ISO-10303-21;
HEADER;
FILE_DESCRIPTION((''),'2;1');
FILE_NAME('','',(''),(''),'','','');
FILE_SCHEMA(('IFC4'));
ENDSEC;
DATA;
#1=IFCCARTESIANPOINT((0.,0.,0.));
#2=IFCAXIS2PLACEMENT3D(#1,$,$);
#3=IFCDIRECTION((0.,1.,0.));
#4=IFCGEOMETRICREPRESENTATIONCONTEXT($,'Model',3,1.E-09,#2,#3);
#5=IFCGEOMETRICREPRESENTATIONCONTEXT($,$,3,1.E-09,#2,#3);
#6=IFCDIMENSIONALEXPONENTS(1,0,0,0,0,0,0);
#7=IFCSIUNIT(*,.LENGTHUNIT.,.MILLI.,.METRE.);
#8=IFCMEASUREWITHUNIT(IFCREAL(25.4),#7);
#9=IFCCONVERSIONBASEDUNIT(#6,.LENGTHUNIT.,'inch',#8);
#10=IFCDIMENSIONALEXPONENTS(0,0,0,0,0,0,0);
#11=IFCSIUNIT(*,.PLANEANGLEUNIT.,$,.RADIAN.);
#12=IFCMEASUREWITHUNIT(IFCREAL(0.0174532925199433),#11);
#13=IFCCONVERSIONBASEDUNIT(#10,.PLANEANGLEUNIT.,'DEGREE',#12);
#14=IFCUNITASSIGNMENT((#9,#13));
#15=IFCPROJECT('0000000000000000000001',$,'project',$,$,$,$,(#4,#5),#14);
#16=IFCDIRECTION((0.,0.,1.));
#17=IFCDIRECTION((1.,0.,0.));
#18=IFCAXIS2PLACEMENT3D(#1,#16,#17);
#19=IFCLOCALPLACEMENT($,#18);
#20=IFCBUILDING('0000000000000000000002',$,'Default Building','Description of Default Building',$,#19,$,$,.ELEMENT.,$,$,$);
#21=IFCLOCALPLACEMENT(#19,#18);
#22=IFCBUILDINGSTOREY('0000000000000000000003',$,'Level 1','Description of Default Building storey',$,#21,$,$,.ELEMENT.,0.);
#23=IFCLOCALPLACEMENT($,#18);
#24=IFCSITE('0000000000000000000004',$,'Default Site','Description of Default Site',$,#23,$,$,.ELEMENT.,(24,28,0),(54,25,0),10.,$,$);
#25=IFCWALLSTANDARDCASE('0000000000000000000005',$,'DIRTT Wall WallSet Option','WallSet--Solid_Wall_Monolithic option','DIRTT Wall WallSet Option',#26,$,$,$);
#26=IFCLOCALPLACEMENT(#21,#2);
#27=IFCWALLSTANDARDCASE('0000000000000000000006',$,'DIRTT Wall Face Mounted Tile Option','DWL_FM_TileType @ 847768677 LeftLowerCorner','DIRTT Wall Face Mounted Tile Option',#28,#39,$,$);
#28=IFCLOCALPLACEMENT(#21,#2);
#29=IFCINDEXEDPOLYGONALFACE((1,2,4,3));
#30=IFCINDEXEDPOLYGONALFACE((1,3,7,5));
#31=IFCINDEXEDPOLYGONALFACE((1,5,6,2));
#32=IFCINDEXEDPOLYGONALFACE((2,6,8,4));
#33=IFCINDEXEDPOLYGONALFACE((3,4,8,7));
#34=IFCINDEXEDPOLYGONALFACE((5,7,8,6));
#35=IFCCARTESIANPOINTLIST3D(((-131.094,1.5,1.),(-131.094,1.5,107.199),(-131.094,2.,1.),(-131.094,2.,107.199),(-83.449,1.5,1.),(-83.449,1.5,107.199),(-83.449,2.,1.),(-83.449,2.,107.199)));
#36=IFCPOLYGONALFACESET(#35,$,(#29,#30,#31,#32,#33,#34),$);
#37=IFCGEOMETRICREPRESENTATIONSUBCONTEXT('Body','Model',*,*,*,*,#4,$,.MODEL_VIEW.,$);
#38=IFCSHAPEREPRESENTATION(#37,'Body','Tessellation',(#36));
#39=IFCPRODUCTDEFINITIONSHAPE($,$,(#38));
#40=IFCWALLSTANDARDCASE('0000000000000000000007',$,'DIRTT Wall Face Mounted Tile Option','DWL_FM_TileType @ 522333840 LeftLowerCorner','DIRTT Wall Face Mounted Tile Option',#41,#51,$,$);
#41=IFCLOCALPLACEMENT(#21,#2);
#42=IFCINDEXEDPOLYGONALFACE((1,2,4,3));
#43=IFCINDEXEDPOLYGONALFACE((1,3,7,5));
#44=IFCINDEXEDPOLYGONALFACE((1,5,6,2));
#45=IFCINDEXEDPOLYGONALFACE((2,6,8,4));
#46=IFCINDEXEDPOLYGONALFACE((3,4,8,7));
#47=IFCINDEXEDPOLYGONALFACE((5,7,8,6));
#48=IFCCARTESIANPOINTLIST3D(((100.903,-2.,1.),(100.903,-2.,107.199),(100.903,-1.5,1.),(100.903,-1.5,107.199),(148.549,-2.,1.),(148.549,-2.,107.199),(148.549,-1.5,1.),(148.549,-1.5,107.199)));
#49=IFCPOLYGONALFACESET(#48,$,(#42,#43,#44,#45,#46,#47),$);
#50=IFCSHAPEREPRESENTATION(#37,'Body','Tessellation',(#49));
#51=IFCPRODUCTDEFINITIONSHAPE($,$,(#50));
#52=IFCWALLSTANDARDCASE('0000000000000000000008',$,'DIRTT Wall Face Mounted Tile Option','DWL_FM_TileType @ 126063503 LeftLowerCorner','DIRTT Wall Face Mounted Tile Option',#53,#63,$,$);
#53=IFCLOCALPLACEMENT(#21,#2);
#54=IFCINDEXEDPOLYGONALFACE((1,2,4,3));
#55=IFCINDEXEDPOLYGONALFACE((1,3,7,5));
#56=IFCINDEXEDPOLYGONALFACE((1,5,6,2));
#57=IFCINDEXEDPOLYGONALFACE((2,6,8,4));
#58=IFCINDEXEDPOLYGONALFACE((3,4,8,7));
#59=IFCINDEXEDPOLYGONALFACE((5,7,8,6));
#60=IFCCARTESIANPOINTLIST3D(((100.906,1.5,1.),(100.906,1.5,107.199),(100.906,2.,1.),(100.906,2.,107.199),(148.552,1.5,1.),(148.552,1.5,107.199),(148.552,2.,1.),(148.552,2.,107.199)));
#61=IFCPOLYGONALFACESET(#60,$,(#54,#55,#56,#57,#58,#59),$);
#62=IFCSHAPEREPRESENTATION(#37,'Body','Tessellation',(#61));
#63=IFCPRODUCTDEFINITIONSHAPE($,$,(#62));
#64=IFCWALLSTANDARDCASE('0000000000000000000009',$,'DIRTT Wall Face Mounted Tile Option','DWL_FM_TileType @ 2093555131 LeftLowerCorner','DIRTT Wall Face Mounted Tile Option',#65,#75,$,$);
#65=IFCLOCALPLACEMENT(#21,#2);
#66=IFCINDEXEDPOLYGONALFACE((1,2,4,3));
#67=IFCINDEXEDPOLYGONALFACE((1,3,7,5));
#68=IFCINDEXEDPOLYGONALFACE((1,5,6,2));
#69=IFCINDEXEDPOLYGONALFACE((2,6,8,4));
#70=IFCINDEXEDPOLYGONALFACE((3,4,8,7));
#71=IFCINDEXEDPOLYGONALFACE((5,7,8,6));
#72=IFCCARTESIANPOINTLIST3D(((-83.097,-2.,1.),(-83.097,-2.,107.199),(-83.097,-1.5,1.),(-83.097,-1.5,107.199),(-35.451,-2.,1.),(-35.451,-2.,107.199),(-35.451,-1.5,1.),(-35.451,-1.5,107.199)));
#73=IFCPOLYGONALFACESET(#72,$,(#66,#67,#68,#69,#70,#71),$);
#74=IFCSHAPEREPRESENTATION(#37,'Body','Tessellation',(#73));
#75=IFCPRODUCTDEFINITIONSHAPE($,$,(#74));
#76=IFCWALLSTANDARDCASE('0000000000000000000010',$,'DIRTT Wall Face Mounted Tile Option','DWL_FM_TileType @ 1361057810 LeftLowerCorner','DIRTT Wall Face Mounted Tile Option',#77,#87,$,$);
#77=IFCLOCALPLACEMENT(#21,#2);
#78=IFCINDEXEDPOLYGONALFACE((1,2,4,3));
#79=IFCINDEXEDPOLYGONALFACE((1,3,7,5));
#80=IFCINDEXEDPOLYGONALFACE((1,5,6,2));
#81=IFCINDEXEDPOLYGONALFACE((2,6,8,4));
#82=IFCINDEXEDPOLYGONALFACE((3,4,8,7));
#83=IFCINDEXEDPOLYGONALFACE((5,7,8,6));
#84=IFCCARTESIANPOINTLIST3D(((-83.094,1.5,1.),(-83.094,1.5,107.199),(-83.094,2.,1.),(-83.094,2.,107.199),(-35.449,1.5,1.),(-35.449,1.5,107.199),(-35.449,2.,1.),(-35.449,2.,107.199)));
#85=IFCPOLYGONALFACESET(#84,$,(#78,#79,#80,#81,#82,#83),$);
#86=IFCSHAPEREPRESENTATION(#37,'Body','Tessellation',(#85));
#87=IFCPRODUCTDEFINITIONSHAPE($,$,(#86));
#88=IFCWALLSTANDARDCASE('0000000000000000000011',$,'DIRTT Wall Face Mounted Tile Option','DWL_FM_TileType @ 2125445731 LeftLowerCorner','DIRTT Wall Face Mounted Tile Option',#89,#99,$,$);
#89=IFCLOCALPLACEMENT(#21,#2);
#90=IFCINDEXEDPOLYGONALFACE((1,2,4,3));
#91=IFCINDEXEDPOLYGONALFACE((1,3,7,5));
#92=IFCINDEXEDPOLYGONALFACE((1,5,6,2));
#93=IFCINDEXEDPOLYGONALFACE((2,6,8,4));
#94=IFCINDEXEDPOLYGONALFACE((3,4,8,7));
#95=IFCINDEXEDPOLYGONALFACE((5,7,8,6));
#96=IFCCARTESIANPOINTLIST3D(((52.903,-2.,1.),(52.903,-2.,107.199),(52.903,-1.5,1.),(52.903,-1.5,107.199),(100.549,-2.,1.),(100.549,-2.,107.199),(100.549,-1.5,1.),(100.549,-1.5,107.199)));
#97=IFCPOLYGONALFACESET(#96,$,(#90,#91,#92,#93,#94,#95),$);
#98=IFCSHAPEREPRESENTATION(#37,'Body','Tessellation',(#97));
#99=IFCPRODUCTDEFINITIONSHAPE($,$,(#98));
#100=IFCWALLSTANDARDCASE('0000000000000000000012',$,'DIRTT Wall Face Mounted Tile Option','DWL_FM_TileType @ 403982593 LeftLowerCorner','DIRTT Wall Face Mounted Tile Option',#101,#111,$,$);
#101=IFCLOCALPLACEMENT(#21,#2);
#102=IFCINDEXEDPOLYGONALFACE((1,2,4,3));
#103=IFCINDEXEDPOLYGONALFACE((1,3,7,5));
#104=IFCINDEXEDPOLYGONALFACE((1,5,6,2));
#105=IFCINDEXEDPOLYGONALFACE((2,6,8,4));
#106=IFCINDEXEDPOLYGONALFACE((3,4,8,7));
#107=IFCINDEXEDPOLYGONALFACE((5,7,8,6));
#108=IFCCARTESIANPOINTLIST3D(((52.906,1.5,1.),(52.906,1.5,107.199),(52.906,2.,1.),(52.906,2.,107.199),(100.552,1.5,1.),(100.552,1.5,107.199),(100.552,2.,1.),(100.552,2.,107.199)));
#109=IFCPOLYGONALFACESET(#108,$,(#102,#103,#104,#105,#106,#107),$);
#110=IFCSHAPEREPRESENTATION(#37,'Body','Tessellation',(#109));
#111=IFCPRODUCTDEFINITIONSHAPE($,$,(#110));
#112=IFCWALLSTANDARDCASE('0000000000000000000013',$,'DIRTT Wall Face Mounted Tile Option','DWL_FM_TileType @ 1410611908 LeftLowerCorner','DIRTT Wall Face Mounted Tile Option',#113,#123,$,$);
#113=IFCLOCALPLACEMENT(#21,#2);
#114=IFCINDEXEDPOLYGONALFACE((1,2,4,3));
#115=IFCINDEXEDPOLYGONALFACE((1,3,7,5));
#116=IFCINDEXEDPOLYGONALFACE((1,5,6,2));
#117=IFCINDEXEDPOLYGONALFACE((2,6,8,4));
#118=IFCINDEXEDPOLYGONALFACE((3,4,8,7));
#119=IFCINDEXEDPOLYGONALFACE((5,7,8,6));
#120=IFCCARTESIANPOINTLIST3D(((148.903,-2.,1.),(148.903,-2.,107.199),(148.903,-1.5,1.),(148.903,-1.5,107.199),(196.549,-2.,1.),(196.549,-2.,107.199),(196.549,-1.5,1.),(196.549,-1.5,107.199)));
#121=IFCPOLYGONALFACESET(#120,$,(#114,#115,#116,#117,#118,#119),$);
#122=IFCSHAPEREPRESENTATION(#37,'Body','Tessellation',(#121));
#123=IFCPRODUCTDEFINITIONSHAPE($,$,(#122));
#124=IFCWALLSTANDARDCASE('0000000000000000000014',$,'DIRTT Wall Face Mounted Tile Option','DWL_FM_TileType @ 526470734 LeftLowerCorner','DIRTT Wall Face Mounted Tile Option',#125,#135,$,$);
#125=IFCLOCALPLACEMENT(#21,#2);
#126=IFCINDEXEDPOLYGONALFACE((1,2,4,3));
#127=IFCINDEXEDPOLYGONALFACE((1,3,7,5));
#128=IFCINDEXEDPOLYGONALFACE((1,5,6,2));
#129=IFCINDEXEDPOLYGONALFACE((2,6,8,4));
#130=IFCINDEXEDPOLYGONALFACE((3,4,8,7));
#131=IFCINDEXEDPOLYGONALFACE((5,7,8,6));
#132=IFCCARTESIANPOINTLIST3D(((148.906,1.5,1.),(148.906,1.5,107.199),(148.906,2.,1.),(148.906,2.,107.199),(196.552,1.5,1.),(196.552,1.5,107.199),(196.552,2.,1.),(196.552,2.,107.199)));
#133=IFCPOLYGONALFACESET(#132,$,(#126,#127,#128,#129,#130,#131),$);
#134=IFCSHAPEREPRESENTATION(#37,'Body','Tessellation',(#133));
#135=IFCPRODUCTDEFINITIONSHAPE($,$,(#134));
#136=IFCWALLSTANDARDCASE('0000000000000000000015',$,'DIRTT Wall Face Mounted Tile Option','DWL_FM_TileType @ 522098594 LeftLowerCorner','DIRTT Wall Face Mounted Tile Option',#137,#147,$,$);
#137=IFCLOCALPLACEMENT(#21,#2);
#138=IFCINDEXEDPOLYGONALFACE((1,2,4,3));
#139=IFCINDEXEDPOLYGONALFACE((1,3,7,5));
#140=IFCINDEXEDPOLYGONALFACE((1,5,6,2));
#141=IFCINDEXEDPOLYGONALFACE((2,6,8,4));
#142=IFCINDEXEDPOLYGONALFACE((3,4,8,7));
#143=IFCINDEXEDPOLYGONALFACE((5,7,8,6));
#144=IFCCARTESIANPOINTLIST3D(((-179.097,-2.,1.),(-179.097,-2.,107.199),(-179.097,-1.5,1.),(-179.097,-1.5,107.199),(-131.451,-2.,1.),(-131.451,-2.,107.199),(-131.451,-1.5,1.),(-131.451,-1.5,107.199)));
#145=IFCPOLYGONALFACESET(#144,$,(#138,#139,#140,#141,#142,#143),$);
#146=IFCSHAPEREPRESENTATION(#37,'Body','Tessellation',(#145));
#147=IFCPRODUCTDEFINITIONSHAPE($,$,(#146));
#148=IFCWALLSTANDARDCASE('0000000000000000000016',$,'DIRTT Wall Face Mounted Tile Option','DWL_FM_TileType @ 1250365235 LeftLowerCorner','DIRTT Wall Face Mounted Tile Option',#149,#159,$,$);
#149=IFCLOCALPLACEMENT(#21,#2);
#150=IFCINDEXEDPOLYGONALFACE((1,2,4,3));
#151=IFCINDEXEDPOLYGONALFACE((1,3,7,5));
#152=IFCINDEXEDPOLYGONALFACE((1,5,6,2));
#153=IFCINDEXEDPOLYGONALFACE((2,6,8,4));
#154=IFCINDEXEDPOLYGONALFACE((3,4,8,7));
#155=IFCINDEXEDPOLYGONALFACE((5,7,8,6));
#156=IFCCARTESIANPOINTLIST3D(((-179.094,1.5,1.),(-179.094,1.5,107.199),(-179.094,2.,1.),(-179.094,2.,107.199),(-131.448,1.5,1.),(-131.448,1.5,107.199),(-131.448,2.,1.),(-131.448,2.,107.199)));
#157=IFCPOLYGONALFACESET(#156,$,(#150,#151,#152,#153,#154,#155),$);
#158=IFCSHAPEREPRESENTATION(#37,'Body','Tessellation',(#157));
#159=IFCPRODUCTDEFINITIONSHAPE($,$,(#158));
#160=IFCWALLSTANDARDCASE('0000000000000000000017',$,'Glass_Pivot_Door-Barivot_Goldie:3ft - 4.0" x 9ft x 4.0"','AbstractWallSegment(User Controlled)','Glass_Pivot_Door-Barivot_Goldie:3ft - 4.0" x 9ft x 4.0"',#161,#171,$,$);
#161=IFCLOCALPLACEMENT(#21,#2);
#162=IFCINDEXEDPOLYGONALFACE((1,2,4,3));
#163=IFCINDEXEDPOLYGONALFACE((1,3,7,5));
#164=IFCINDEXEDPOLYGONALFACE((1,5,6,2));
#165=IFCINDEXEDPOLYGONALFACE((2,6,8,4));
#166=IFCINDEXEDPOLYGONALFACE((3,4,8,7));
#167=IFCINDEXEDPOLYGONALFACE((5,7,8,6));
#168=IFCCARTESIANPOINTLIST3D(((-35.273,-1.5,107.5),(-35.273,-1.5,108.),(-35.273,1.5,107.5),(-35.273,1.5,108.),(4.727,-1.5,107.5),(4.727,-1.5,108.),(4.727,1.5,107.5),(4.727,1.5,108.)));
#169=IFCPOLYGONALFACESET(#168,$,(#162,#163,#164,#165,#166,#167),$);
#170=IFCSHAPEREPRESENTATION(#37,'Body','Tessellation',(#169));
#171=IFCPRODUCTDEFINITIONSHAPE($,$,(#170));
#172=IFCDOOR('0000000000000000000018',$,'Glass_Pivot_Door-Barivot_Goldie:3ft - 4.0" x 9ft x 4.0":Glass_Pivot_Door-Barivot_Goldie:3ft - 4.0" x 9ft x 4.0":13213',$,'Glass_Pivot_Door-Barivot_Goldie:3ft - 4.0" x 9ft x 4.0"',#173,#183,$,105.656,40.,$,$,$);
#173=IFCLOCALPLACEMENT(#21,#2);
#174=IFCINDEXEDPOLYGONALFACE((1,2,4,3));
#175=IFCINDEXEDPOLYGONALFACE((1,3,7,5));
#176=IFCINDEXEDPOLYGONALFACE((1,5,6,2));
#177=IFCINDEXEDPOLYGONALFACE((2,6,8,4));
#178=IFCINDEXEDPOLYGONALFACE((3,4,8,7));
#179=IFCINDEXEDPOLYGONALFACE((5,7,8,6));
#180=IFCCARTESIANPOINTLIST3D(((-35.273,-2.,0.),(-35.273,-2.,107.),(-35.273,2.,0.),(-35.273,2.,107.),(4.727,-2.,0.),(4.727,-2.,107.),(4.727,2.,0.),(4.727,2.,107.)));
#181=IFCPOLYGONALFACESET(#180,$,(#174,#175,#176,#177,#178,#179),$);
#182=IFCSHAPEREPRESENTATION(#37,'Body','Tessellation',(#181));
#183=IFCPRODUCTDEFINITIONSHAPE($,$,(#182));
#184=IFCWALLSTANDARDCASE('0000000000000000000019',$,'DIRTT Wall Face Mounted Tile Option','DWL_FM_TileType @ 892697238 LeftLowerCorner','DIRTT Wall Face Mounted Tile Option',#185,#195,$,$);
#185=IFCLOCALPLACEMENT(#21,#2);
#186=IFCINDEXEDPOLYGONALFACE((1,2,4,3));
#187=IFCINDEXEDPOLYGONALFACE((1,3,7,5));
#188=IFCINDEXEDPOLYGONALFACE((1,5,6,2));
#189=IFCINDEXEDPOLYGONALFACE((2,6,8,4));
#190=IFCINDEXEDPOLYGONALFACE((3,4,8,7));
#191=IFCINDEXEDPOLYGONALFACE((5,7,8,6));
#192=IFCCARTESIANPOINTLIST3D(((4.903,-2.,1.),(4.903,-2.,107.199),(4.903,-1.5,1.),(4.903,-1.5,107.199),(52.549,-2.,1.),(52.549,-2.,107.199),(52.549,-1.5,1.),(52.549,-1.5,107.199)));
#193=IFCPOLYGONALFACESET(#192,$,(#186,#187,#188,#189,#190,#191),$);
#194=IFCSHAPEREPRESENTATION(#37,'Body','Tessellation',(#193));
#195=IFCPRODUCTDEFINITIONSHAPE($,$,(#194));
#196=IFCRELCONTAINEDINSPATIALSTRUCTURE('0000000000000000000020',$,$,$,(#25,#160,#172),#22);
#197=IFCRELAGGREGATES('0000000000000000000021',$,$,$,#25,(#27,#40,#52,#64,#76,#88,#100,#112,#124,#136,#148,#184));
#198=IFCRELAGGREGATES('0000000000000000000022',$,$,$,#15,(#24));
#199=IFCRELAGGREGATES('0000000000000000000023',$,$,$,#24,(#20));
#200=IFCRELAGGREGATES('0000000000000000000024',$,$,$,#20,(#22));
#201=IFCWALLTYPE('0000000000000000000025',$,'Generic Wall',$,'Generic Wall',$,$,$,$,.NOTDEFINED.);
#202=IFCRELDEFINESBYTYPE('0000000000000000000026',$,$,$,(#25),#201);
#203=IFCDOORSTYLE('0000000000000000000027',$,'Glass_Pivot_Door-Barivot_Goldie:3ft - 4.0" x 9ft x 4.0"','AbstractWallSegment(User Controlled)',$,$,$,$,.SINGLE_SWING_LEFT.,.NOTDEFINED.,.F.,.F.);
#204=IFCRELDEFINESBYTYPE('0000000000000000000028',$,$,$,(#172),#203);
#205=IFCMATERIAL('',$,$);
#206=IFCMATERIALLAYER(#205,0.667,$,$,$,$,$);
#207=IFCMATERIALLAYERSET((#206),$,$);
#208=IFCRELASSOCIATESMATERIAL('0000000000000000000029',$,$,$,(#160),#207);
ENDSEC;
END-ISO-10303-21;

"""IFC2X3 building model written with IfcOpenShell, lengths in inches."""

from ifc_helpers import new_model, entity, si_unit, converted_unit, direction, frame, origin, origin_with_axes, origin_2d_with_axis, place, context, subcontext, project, spatial, rectangle, extrude, source, transform, mapped, material, layer, layer_set, layer_usage, type_object, type_shapes, element, fill, aggregate, save


model = new_model("IFC2X3")

# Units and contexts
model_context = context("Model", 3, precision=1e-09, world=origin(), true_north=direction((0.0, 1.0, 0.0)))
context_of_model = context(None, 3, precision=1e-09, world=origin(), true_north=direction((0.0, 1.0, 0.0)))
body_context = subcontext(model_context, "Body", "Model", "MODEL_VIEW")
ifc_project = project(units=[converted_unit("LENGTHUNIT", "inch", entity("IfcReal", 25.4), si_unit("LENGTHUNIT", "METRE", prefix="MILLI"), dimensions=[1, 0, 0, 0, 0, 0, 0]), converted_unit("PLANEANGLEUNIT", "DEGREE", entity("IfcReal", 0.0174532925199433), si_unit("PLANEANGLEUNIT", "RADIAN"), dimensions=[0, 0, 0, 0, 0, 0, 0])], contexts=[model_context, context_of_model])

# Site, building, storey
site_placement = place(None, origin_with_axes())
site = spatial("IfcSite", under=ifc_project, at=site_placement, Name="Default Site", Description="Description of Default Site", CompositionType="ELEMENT", RefLatitude=(24, 28, 0), RefLongitude=(54, 25, 0), RefElevation=10.0)
building_placement = place(None, origin_with_axes())
building = spatial("IfcBuilding", under=site, at=building_placement, Name="Default Building", Description="Description of Default Building", CompositionType="ELEMENT")
storey_placement = place(building_placement, origin_with_axes())
storey = spatial("IfcBuildingStorey", under=building, at=storey_placement, Name="Level 1", Description="Description of Default Building storey", CompositionType="ELEMENT", Elevation=0.0)

# Wall
wall_type_1 = type_object("IfcWallType", Name="Generic Wall", ApplicableOccurrence="Generic Wall", PredefinedType="NOTDEFINED")
placement_1 = place(storey_placement, origin_with_axes())
wall_1 = element("IfcWallStandardCase", 1, at=placement_1, inside=storey, type_object=wall_type_1, Name="DIRTT Wall WallSet Option", Description="WallSet--Solid_Wall_Monolithic option", ObjectType="DIRTT Wall WallSet Option")

# Walls
wall_2_placement = place(placement_1, origin_with_axes())
wall_2 = element("IfcWallStandardCase", 2, at=wall_2_placement, Name="DIRTT Wall Face Mounted Tile Option", Description="DWL_FM_TileType @ 847768677 LeftLowerCorner", ObjectType="DIRTT Wall Face Mounted Tile Option", context=body_context, shape_type="SweptSolid", body=[
    extrude(rectangle(XDim=47.646, YDim=0.5, at=origin_2d_with_axis()), frame((-107.271, 1.75, 1.0), z_axis=(0.0, 0.0, 1.0), x_axis=(-1.0, 0.0, 0.0)), (0.0, 0.0, 1.0), 106.199),
])
wall_3_placement = place(placement_1, origin_with_axes())
wall_3 = element("IfcWallStandardCase", 3, at=wall_3_placement, Name="DIRTT Wall Face Mounted Tile Option", Description="DWL_FM_TileType @ 522333840 LeftLowerCorner", ObjectType="DIRTT Wall Face Mounted Tile Option", context=body_context, shape_type="SweptSolid", body=[
    extrude(rectangle(XDim=47.646, YDim=0.5, at=origin_2d_with_axis()), frame((124.726, -1.75, 1.0), z_axis=(0.0, 0.0, 1.0), x_axis=(1.0, 0.0, 0.0)), (0.0, 0.0, 1.0), 106.199),
])
wall_4_placement = place(placement_1, origin_with_axes())
wall_4 = element("IfcWallStandardCase", 4, at=wall_4_placement, Name="DIRTT Wall Face Mounted Tile Option", Description="DWL_FM_TileType @ 126063503 LeftLowerCorner", ObjectType="DIRTT Wall Face Mounted Tile Option", context=body_context, shape_type="SweptSolid", body=[
    extrude(rectangle(XDim=47.646, YDim=0.5, at=origin_2d_with_axis()), frame((124.729, 1.75, 1.0), z_axis=(0.0, 0.0, 1.0), x_axis=(-1.0, 0.0, 0.0)), (0.0, 0.0, 1.0), 106.199),
])
wall_5_placement = place(placement_1, origin_with_axes())
wall_5 = element("IfcWallStandardCase", 5, at=wall_5_placement, Name="DIRTT Wall Face Mounted Tile Option", Description="DWL_FM_TileType @ 2093555131 LeftLowerCorner", ObjectType="DIRTT Wall Face Mounted Tile Option", context=body_context, shape_type="SweptSolid", body=[
    extrude(rectangle(XDim=47.646, YDim=0.5, at=origin_2d_with_axis()), frame((-59.274, -1.75, 1.0), z_axis=(0.0, 0.0, 1.0), x_axis=(1.0, 0.0, 0.0)), (0.0, 0.0, 1.0), 106.199),
])
wall_6_placement = place(placement_1, origin_with_axes())
wall_6 = element("IfcWallStandardCase", 6, at=wall_6_placement, Name="DIRTT Wall Face Mounted Tile Option", Description="DWL_FM_TileType @ 1361057810 LeftLowerCorner", ObjectType="DIRTT Wall Face Mounted Tile Option", context=body_context, shape_type="SweptSolid", body=[
    extrude(rectangle(XDim=47.646, YDim=0.5, at=origin_2d_with_axis()), frame((-59.271, 1.75, 1.0), z_axis=(0.0, 0.0, 1.0), x_axis=(-1.0, 0.0, 0.0)), (0.0, 0.0, 1.0), 106.199),
])
wall_7_placement = place(placement_1, origin_with_axes())
wall_7 = element("IfcWallStandardCase", 7, at=wall_7_placement, Name="DIRTT Wall Face Mounted Tile Option", Description="DWL_FM_TileType @ 2125445731 LeftLowerCorner", ObjectType="DIRTT Wall Face Mounted Tile Option", context=body_context, shape_type="SweptSolid", body=[
    extrude(rectangle(XDim=47.646, YDim=0.5, at=origin_2d_with_axis()), frame((76.726, -1.75, 1.0), z_axis=(0.0, 0.0, 1.0), x_axis=(1.0, 0.0, 0.0)), (0.0, 0.0, 1.0), 106.199),
])
wall_8_placement = place(placement_1, origin_with_axes())
wall_8 = element("IfcWallStandardCase", 8, at=wall_8_placement, Name="DIRTT Wall Face Mounted Tile Option", Description="DWL_FM_TileType @ 403982593 LeftLowerCorner", ObjectType="DIRTT Wall Face Mounted Tile Option", context=body_context, shape_type="SweptSolid", body=[
    extrude(rectangle(XDim=47.646, YDim=0.5, at=origin_2d_with_axis()), frame((76.729, 1.75, 1.0), z_axis=(0.0, 0.0, 1.0), x_axis=(-1.0, 0.0, 0.0)), (0.0, 0.0, 1.0), 106.199),
])
wall_9_placement = place(placement_1, origin_with_axes())
wall_9 = element("IfcWallStandardCase", 9, at=wall_9_placement, Name="DIRTT Wall Face Mounted Tile Option", Description="DWL_FM_TileType @ 1410611908 LeftLowerCorner", ObjectType="DIRTT Wall Face Mounted Tile Option", context=body_context, shape_type="SweptSolid", body=[
    extrude(rectangle(XDim=47.646, YDim=0.5, at=origin_2d_with_axis()), frame((172.726, -1.75, 1.0), z_axis=(0.0, 0.0, 1.0), x_axis=(1.0, 0.0, 0.0)), (0.0, 0.0, 1.0), 106.199),
])
wall_10_placement = place(placement_1, origin_with_axes())
wall_10 = element("IfcWallStandardCase", 10, at=wall_10_placement, Name="DIRTT Wall Face Mounted Tile Option", Description="DWL_FM_TileType @ 526470734 LeftLowerCorner", ObjectType="DIRTT Wall Face Mounted Tile Option", context=body_context, shape_type="SweptSolid", body=[
    extrude(rectangle(XDim=47.646, YDim=0.5, at=origin_2d_with_axis()), frame((172.729, 1.75, 1.0), z_axis=(0.0, 0.0, 1.0), x_axis=(-1.0, 0.0, 0.0)), (0.0, 0.0, 1.0), 106.199),
])
wall_11_placement = place(placement_1, origin_with_axes())
wall_11 = element("IfcWallStandardCase", 11, at=wall_11_placement, Name="DIRTT Wall Face Mounted Tile Option", Description="DWL_FM_TileType @ 522098594 LeftLowerCorner", ObjectType="DIRTT Wall Face Mounted Tile Option", context=body_context, shape_type="SweptSolid", body=[
    extrude(rectangle(XDim=47.646, YDim=0.5, at=origin_2d_with_axis()), frame((-155.274, -1.75, 1.0), z_axis=(0.0, 0.0, 1.0), x_axis=(1.0, 0.0, 0.0)), (0.0, 0.0, 1.0), 106.199),
])
wall_12_placement = place(placement_1, origin_with_axes())
wall_12 = element("IfcWallStandardCase", 12, at=wall_12_placement, Name="DIRTT Wall Face Mounted Tile Option", Description="DWL_FM_TileType @ 1250365235 LeftLowerCorner", ObjectType="DIRTT Wall Face Mounted Tile Option", context=body_context, shape_type="SweptSolid", body=[
    extrude(rectangle(XDim=47.646, YDim=0.5, at=origin_2d_with_axis()), frame((-155.271, 1.75, 1.0), z_axis=(0.0, 0.0, 1.0), x_axis=(-1.0, 0.0, 0.0)), (0.0, 0.0, 1.0), 106.199),
])

# Wall, opening, door
ifc_material = material(Name="")
ifc_layer = layer(ifc_material, 0.667)
ifc_layer_set = layer_set([ifc_layer])
ifc_layer_usage = layer_usage(ifc_layer_set, "AXIS2", "NEGATIVE", 0.333)
placement_2 = place(placement_1, origin_with_axes())
wall_13 = element("IfcWallStandardCase", 13, at=placement_2, inside=storey, material=ifc_layer_usage, Name="Glass_Pivot_Door-Barivot_Goldie:3ft - 4.0\" x 9ft x 4.0\"", Description="AbstractWallSegment(User Controlled)", ObjectType="Glass_Pivot_Door-Barivot_Goldie:3ft - 4.0\" x 9ft x 4.0\"", context=body_context, shape_type="SweptSolid", body=[
    extrude(rectangle(XDim=40.0, YDim=3.0, at=origin_2d_with_axis()), frame((-15.273, 0.0, 0.0), z_axis=(0.0, 0.0, 1.0), x_axis=(1.0, 0.0, 0.0)), (0.0, 0.0, 1.0), 108.0),
])
opening = element("IfcOpeningElement", 14, at=placement_2, cuts=wall_13, ObjectType="Opening", context=body_context, shape_type="SweptSolid", body=[
    extrude(rectangle(XDim=40.0, YDim=4.0, at=origin_2d_with_axis()), frame((-15.273, 0.0, 0.0), z_axis=(0.0, 0.0, 1.0), x_axis=(1.0, 0.0, 0.0)), (0.0, 0.0, 1.0), 107.5),
])
door_style = type_object("IfcDoorStyle", Name="Glass_Pivot_Door-Barivot_Goldie:3ft - 4.0\" x 9ft x 4.0\"", Description="AbstractWallSegment(User Controlled)", ConstructionType="NOTDEFINED", OperationType="SINGLE_SWING_LEFT", ParameterTakesPrecedence=False, Sizeable=False)
shared_shape = source(origin(), model_context, "Body", "SweptSolid", [
    extrude(rectangle(XDim=40.0, YDim=4.0, at=origin_2d_with_axis()), frame((20.0, 0.0, 0.0), z_axis=(0.0, 0.0, 1.0), x_axis=(1.0, 0.0, 0.0)), (0.0, 0.0, 1.0), 107.0),
])
type_shapes(door_style, [shared_shape])
door_placement = place(placement_2, frame((-35.273, 0.0, 0.0), z_axis=(0.0, 0.0, 1.0), x_axis=(1.0, 0.0, 0.0)))
door = element("IfcDoor", 15, at=door_placement, inside=storey, type_object=door_style, Name="Glass_Pivot_Door-Barivot_Goldie:3ft - 4.0\" x 9ft x 4.0\":Glass_Pivot_Door-Barivot_Goldie:3ft - 4.0\" x 9ft x 4.0\":13213", ObjectType="Glass_Pivot_Door-Barivot_Goldie:3ft - 4.0\" x 9ft x 4.0\"", OverallHeight=105.656, OverallWidth=40.0, context=body_context, shape_type="MappedRepresentation", body=[
    mapped(shared_shape, transform((0.0, 0.0, 0.0), scale=1.0)),
])
fill(opening, door)

# Wall
wall_14_placement = place(placement_1, origin_with_axes())
wall_14 = element("IfcWallStandardCase", 16, at=wall_14_placement, Name="DIRTT Wall Face Mounted Tile Option", Description="DWL_FM_TileType @ 892697238 LeftLowerCorner", ObjectType="DIRTT Wall Face Mounted Tile Option", context=body_context, shape_type="SweptSolid", body=[
    extrude(rectangle(XDim=47.646, YDim=0.5, at=origin_2d_with_axis()), frame((28.726, -1.75, 1.0), z_axis=(0.0, 0.0, 1.0), x_axis=(1.0, 0.0, 0.0)), (0.0, 0.0, 1.0), 106.199),
])
aggregate(wall_1, [wall_2, wall_3, wall_4, wall_5, wall_6, wall_7, wall_8, wall_9, wall_10, wall_11, wall_12, wall_14])

save(model, "model.ifc")
